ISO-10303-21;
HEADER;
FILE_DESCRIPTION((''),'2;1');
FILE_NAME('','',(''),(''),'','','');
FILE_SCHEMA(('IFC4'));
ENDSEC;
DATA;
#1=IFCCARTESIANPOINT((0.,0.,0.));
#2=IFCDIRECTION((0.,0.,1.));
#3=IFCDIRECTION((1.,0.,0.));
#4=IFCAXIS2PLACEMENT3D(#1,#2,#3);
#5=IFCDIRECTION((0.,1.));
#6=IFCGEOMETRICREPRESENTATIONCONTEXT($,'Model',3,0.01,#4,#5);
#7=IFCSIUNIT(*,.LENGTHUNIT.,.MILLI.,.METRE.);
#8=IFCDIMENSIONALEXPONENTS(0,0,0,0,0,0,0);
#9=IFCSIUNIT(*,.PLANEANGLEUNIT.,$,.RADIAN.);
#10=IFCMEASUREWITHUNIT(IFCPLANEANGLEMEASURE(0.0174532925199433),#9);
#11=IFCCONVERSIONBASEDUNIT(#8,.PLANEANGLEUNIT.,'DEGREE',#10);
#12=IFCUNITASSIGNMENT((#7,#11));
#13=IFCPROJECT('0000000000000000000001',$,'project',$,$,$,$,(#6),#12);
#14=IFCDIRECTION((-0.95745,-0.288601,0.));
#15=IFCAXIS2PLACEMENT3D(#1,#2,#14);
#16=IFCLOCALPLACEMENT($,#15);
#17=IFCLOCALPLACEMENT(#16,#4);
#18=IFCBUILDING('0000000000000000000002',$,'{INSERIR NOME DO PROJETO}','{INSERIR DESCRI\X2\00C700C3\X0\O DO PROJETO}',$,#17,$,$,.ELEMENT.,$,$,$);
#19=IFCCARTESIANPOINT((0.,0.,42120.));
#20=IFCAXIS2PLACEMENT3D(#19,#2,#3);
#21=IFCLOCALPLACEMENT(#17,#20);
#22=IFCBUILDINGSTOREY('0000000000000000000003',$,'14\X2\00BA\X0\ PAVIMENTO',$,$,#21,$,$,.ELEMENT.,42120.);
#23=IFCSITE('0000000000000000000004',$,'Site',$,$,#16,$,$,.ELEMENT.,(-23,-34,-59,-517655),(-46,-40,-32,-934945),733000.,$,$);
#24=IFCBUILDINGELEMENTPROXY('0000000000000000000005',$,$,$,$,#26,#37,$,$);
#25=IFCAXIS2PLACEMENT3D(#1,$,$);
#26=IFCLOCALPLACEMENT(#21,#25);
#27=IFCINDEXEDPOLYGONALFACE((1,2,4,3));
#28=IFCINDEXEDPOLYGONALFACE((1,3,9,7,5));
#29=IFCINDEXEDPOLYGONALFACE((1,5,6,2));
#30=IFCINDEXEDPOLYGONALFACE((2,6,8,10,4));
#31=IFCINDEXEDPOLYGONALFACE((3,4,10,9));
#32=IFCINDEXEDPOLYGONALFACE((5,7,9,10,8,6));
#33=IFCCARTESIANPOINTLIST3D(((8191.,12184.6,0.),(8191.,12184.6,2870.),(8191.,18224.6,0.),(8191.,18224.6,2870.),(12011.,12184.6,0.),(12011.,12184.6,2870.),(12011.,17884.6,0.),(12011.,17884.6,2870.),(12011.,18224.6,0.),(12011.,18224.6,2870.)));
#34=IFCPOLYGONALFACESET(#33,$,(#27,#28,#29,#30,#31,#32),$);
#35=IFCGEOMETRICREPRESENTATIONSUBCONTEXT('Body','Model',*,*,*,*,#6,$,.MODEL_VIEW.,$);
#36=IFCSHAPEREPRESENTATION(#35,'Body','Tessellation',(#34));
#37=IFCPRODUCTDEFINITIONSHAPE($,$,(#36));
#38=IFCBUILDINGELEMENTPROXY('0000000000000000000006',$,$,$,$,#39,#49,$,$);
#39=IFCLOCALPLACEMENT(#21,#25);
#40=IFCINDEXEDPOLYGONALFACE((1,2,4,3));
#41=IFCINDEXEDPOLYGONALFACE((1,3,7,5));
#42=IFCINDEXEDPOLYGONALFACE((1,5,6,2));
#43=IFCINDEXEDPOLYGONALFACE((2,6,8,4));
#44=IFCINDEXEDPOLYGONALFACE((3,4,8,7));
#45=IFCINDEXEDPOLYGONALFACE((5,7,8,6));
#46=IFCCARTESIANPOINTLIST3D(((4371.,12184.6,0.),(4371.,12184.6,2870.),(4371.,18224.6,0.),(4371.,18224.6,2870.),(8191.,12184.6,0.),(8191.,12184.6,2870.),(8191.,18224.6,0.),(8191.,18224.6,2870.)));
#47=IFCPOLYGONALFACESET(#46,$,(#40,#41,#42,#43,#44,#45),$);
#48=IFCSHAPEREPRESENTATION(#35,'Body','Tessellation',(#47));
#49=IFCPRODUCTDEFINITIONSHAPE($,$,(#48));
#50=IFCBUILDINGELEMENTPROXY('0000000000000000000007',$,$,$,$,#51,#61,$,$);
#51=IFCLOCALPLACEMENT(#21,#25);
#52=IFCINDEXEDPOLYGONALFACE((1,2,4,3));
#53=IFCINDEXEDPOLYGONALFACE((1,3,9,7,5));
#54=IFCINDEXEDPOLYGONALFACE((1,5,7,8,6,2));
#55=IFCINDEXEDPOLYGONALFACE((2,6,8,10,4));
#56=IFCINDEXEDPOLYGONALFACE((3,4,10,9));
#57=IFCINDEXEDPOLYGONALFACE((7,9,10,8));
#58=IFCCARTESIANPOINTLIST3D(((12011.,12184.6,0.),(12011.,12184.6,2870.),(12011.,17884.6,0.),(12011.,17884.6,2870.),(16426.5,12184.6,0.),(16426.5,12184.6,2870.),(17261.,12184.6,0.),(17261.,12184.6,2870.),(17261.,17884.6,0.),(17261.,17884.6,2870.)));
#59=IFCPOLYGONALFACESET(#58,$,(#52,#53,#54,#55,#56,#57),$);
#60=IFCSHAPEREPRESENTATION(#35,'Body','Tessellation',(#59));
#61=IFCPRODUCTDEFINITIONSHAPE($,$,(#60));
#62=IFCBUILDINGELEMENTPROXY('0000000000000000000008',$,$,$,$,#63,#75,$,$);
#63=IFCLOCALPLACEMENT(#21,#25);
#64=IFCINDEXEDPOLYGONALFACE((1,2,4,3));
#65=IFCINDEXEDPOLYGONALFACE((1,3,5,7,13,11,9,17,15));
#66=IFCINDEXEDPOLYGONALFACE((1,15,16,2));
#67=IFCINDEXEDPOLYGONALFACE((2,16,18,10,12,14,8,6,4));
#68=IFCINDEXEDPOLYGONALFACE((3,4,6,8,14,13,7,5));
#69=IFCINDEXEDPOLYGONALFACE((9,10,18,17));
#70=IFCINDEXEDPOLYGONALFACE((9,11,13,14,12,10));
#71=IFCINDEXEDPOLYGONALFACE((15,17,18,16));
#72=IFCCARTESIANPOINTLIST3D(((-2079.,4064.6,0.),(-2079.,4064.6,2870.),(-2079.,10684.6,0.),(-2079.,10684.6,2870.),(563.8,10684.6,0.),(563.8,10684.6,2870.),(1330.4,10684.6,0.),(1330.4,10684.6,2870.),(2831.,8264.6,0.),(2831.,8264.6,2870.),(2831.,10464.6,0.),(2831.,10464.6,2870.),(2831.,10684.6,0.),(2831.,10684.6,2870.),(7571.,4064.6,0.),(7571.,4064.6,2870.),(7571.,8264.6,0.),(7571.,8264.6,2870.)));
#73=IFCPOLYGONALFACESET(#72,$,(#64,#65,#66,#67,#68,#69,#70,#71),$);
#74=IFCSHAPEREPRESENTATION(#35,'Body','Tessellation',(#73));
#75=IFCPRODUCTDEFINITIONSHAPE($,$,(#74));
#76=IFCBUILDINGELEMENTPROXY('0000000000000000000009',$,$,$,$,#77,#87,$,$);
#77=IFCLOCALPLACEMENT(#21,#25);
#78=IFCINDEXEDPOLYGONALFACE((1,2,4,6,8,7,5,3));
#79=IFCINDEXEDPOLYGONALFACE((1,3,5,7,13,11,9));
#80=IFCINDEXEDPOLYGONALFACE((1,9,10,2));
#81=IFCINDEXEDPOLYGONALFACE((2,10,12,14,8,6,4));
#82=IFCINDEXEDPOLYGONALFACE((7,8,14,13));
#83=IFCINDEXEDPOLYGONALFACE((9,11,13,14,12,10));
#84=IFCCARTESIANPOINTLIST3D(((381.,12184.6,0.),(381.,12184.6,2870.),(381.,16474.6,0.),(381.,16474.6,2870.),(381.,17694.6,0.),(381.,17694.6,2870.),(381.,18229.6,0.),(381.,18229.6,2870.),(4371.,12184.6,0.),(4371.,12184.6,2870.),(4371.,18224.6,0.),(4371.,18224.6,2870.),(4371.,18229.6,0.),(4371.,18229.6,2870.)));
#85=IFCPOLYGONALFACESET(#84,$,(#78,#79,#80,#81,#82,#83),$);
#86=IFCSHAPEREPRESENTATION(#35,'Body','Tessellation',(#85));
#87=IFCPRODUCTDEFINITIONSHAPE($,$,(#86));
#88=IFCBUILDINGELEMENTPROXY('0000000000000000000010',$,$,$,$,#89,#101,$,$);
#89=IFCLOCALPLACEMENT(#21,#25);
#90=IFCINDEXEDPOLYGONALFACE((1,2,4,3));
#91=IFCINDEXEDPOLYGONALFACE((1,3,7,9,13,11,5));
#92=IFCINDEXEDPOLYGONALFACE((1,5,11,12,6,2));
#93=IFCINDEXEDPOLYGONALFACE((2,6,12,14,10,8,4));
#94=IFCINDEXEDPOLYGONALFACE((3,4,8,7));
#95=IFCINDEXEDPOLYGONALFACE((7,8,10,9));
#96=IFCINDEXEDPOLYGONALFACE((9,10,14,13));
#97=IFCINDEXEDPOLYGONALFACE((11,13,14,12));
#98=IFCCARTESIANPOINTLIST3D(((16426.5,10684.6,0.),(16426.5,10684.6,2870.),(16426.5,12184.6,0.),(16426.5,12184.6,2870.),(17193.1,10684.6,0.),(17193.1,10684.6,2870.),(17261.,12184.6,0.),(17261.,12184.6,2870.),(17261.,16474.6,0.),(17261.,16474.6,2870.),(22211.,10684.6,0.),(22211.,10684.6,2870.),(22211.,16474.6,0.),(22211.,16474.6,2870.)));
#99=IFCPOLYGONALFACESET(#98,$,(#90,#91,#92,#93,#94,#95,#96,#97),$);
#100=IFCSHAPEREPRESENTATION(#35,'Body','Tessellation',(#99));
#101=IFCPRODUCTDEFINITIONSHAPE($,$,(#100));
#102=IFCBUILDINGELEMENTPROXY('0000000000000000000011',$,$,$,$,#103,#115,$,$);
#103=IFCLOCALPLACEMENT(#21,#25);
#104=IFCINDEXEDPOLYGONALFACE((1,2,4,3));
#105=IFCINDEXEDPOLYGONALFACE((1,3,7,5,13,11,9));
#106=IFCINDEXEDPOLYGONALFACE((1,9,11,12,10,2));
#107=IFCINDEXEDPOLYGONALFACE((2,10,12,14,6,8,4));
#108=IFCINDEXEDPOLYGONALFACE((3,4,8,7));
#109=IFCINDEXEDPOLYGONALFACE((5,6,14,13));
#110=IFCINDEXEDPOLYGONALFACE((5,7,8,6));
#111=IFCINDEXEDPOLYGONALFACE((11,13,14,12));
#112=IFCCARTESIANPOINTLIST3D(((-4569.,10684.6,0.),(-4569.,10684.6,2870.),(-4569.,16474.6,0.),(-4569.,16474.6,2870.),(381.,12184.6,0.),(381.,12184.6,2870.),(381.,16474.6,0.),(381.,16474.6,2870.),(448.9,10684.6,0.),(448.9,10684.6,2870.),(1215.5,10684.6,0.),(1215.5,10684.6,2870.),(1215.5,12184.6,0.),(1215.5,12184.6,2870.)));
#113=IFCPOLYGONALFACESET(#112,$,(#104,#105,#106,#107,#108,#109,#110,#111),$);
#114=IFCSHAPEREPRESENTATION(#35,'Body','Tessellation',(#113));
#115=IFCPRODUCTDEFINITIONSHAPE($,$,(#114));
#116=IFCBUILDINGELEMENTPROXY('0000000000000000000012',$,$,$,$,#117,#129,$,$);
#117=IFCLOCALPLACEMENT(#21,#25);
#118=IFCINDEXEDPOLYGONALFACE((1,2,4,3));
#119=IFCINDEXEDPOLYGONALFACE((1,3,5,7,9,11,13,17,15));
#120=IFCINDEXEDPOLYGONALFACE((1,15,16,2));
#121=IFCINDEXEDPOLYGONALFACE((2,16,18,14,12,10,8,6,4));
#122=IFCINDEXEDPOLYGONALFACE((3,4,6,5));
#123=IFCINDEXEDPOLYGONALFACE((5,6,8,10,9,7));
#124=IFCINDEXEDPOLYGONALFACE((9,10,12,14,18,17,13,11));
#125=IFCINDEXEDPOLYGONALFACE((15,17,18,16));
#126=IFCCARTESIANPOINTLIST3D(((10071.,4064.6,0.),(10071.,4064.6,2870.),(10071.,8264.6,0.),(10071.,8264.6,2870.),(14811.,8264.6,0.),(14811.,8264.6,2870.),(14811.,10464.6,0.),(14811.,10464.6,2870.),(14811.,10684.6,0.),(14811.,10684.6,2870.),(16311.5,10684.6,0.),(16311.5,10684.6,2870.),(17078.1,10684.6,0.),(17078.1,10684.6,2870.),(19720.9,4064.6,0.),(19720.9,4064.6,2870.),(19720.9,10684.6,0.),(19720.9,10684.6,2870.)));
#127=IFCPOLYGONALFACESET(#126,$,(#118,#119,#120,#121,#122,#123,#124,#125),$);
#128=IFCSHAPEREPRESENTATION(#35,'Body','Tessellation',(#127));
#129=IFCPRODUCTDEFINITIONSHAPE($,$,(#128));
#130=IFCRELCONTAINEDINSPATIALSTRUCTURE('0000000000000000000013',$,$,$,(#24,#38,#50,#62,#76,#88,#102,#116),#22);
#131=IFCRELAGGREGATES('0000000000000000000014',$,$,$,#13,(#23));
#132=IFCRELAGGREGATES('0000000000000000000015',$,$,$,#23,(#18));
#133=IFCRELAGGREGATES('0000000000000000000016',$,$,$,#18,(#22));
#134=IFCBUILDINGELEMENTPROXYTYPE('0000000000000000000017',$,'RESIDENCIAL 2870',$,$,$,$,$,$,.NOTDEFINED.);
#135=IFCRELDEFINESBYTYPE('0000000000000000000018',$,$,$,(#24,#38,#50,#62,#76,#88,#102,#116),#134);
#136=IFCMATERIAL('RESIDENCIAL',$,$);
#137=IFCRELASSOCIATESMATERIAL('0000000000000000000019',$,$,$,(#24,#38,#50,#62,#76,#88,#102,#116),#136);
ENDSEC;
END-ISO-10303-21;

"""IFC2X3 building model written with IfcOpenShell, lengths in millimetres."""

from ifc_helpers import new_model, entity, si_unit, converted_unit, direction, frame, origin_with_axes, place, context, subcontext, project, spatial, polyline, outline, extrude, material, type_object, element, save


model = new_model("IFC2X3")

# Units and contexts
model_context = context("Model", 3, precision=0.01, world=origin_with_axes(), true_north=direction((0.0, 1.0)))
body_context = subcontext(model_context, "Body", "Model", "MODEL_VIEW")
ifc_project = project(units=[si_unit("LENGTHUNIT", "METRE", prefix="MILLI"), converted_unit("PLANEANGLEUNIT", "DEGREE", entity("IfcPlaneAngleMeasure", 0.0174532925199433), si_unit("PLANEANGLEUNIT", "RADIAN"), dimensions=[0, 0, 0, 0, 0, 0, 0])], contexts=[model_context])

# Site, building, storey
site_placement = place(None, frame((0.0, 0.0, 0.0), z_axis=(0.0, 0.0, 1.0), x_axis=(-0.95745, -0.288601, 0.0)))
site = spatial("IfcSite", under=ifc_project, at=site_placement, Name="Site", CompositionType="ELEMENT", RefLatitude=(-23, -34, -59, -517655), RefLongitude=(-46, -40, -32, -934945), RefElevation=733000.0)
building_placement = place(site_placement, origin_with_axes())
building = spatial("IfcBuilding", under=site, at=building_placement, Name="{INSERIR NOME DO PROJETO}", Description="{INSERIR DESCRIÇÃO DO PROJETO}", CompositionType="ELEMENT")
storey_placement = place(building_placement, frame((0.0, 0.0, 42120.0), z_axis=(0.0, 0.0, 1.0), x_axis=(1.0, 0.0, 0.0)))
storey = spatial("IfcBuildingStorey", under=building, at=storey_placement, Name="14º PAVIMENTO", CompositionType="ELEMENT", Elevation=42120.0)

# Building element proxies
ifc_material_1 = material(Name="RESIDENCIAL")
building_element_proxy_type_1 = type_object("IfcBuildingElementProxyType", Name="RESIDENCIAL 2870", PredefinedType="NOTDEFINED")
proxy_1_placement = place(storey_placement, frame((8191.0, 18224.6, 0.0), z_axis=(0.0, 0.0, 1.0), x_axis=(1.0, 0.0, 0.0)))
element("IfcBuildingElementProxy", 1, at=proxy_1_placement, inside=storey, type_object=building_element_proxy_type_1, material=ifc_material_1, context=body_context, shape_type="SweptSolid", body=[
    extrude(outline(polyline([(0.0, 0.0), (0.0, -6040.0), (3820.0, -6040.0), (3820.0, -340.0), (3820.0, 0.0), (0.0, 0.0)])), origin_with_axes(), (0.0, 0.0, 1.0), 2870.0),
])
proxy_2_placement = place(storey_placement, frame((4371.0, 18224.6, 0.0), z_axis=(0.0, 0.0, 1.0), x_axis=(1.0, 0.0, 0.0)))
element("IfcBuildingElementProxy", 2, at=proxy_2_placement, inside=storey, type_object=building_element_proxy_type_1, material=ifc_material_1, context=body_context, shape_type="SweptSolid", body=[
    extrude(outline(polyline([(0.0, 0.0), (0.0, -6040.0), (3820.0, -6040.0), (3820.0, 0.0), (0.0, 0.0)])), origin_with_axes(), (0.0, 0.0, 1.0), 2870.0),
])
proxy_3_placement = place(storey_placement, frame((12011.0, 12184.6, 0.0), z_axis=(0.0, 0.0, 1.0), x_axis=(1.0, 0.0, 0.0)))
element("IfcBuildingElementProxy", 3, at=proxy_3_placement, inside=storey, type_object=building_element_proxy_type_1, material=ifc_material_1, context=body_context, shape_type="SweptSolid", body=[
    extrude(outline(polyline([(0.0, 0.0), (4415.5, 0.0), (5250.0, 0.0), (5250.0, 5700.0), (0.0, 5700.0), (0.0, 0.0)])), origin_with_axes(), (0.0, 0.0, 1.0), 2870.0),
])
proxy_4_placement = place(storey_placement, frame((-2079.0, 4064.6, 0.0), z_axis=(0.0, 0.0, 1.0), x_axis=(1.0, 0.0, 0.0)))
element("IfcBuildingElementProxy", 4, at=proxy_4_placement, inside=storey, type_object=building_element_proxy_type_1, material=ifc_material_1, context=body_context, shape_type="SweptSolid", body=[
    extrude(outline(polyline([(0.0, 0.0), (9650.0, 0.0), (9650.0, 4200.0), (4910.0, 4200.0), (4910.0, 6400.0), (4910.0, 6620.0), (3409.4, 6620.0), (2642.8, 6620.0), (0.0, 6620.0), (0.0, 0.0)])), origin_with_axes(), (0.0, 0.0, 1.0), 2870.0),
])
proxy_5_placement = place(storey_placement, frame((381.0, 16474.6, 0.0), z_axis=(0.0, 0.0, 1.0), x_axis=(1.0, 0.0, 0.0)))
element("IfcBuildingElementProxy", 5, at=proxy_5_placement, inside=storey, type_object=building_element_proxy_type_1, material=ifc_material_1, context=body_context, shape_type="SweptSolid", body=[
    extrude(outline(polyline([(0.0, 0.0), (0.0, -4290.0), (3990.0, -4290.0), (3990.0, 1750.0), (3990.0, 1755.0), (0.0, 1755.0), (0.0, 1220.0), (0.0, 0.0)])), origin_with_axes(), (0.0, 0.0, 1.0), 2870.0),
])
proxy_6_placement = place(storey_placement, frame((17261.0, 12184.6, 0.0), z_axis=(0.0, 0.0, 1.0), x_axis=(1.0, 0.0, 0.0)))
element("IfcBuildingElementProxy", 6, at=proxy_6_placement, inside=storey, type_object=building_element_proxy_type_1, material=ifc_material_1, context=body_context, shape_type="SweptSolid", body=[
    extrude(outline(polyline([(0.0, 0.0), (-834.5, 0.0), (-834.5, -1500.0), (-67.9, -1500.0), (4950.0, -1500.0), (4950.0, 4290.0), (0.0, 4290.0), (0.0, 0.0)])), origin_with_axes(), (0.0, 0.0, 1.0), 2870.0),
])
proxy_7_placement = place(storey_placement, frame((-4569.0, 16474.6, 0.0), z_axis=(0.0, 0.0, 1.0), x_axis=(1.0, 0.0, 0.0)))
element("IfcBuildingElementProxy", 7, at=proxy_7_placement, inside=storey, type_object=building_element_proxy_type_1, material=ifc_material_1, context=body_context, shape_type="SweptSolid", body=[
    extrude(outline(polyline([(0.0, 0.0), (0.0, -5790.0), (5017.9, -5790.0), (5784.5, -5790.0), (5784.5, -4290.0), (4950.0, -4290.0), (4950.0, 0.0), (0.0, 0.0)])), origin_with_axes(), (0.0, 0.0, 1.0), 2870.0),
])
proxy_8_placement = place(storey_placement, frame((19720.9, 4064.6, 0.0), z_axis=(0.0, 0.0, 1.0), x_axis=(1.0, 0.0, 0.0)))
element("IfcBuildingElementProxy", 8, at=proxy_8_placement, inside=storey, type_object=building_element_proxy_type_1, material=ifc_material_1, context=body_context, shape_type="SweptSolid", body=[
    extrude(outline(polyline([(0.0, 0.0), (0.0, 6620.0), (-2642.8, 6620.0), (-3409.4, 6620.0), (-4910.0, 6620.0), (-4910.0, 6400.0), (-4910.0, 4200.0), (-9650.0, 4200.0), (-9650.0, 0.0), (0.0, 0.0)])), origin_with_axes(), (0.0, 0.0, 1.0), 2870.0),
])

save(model, "model.ifc")
